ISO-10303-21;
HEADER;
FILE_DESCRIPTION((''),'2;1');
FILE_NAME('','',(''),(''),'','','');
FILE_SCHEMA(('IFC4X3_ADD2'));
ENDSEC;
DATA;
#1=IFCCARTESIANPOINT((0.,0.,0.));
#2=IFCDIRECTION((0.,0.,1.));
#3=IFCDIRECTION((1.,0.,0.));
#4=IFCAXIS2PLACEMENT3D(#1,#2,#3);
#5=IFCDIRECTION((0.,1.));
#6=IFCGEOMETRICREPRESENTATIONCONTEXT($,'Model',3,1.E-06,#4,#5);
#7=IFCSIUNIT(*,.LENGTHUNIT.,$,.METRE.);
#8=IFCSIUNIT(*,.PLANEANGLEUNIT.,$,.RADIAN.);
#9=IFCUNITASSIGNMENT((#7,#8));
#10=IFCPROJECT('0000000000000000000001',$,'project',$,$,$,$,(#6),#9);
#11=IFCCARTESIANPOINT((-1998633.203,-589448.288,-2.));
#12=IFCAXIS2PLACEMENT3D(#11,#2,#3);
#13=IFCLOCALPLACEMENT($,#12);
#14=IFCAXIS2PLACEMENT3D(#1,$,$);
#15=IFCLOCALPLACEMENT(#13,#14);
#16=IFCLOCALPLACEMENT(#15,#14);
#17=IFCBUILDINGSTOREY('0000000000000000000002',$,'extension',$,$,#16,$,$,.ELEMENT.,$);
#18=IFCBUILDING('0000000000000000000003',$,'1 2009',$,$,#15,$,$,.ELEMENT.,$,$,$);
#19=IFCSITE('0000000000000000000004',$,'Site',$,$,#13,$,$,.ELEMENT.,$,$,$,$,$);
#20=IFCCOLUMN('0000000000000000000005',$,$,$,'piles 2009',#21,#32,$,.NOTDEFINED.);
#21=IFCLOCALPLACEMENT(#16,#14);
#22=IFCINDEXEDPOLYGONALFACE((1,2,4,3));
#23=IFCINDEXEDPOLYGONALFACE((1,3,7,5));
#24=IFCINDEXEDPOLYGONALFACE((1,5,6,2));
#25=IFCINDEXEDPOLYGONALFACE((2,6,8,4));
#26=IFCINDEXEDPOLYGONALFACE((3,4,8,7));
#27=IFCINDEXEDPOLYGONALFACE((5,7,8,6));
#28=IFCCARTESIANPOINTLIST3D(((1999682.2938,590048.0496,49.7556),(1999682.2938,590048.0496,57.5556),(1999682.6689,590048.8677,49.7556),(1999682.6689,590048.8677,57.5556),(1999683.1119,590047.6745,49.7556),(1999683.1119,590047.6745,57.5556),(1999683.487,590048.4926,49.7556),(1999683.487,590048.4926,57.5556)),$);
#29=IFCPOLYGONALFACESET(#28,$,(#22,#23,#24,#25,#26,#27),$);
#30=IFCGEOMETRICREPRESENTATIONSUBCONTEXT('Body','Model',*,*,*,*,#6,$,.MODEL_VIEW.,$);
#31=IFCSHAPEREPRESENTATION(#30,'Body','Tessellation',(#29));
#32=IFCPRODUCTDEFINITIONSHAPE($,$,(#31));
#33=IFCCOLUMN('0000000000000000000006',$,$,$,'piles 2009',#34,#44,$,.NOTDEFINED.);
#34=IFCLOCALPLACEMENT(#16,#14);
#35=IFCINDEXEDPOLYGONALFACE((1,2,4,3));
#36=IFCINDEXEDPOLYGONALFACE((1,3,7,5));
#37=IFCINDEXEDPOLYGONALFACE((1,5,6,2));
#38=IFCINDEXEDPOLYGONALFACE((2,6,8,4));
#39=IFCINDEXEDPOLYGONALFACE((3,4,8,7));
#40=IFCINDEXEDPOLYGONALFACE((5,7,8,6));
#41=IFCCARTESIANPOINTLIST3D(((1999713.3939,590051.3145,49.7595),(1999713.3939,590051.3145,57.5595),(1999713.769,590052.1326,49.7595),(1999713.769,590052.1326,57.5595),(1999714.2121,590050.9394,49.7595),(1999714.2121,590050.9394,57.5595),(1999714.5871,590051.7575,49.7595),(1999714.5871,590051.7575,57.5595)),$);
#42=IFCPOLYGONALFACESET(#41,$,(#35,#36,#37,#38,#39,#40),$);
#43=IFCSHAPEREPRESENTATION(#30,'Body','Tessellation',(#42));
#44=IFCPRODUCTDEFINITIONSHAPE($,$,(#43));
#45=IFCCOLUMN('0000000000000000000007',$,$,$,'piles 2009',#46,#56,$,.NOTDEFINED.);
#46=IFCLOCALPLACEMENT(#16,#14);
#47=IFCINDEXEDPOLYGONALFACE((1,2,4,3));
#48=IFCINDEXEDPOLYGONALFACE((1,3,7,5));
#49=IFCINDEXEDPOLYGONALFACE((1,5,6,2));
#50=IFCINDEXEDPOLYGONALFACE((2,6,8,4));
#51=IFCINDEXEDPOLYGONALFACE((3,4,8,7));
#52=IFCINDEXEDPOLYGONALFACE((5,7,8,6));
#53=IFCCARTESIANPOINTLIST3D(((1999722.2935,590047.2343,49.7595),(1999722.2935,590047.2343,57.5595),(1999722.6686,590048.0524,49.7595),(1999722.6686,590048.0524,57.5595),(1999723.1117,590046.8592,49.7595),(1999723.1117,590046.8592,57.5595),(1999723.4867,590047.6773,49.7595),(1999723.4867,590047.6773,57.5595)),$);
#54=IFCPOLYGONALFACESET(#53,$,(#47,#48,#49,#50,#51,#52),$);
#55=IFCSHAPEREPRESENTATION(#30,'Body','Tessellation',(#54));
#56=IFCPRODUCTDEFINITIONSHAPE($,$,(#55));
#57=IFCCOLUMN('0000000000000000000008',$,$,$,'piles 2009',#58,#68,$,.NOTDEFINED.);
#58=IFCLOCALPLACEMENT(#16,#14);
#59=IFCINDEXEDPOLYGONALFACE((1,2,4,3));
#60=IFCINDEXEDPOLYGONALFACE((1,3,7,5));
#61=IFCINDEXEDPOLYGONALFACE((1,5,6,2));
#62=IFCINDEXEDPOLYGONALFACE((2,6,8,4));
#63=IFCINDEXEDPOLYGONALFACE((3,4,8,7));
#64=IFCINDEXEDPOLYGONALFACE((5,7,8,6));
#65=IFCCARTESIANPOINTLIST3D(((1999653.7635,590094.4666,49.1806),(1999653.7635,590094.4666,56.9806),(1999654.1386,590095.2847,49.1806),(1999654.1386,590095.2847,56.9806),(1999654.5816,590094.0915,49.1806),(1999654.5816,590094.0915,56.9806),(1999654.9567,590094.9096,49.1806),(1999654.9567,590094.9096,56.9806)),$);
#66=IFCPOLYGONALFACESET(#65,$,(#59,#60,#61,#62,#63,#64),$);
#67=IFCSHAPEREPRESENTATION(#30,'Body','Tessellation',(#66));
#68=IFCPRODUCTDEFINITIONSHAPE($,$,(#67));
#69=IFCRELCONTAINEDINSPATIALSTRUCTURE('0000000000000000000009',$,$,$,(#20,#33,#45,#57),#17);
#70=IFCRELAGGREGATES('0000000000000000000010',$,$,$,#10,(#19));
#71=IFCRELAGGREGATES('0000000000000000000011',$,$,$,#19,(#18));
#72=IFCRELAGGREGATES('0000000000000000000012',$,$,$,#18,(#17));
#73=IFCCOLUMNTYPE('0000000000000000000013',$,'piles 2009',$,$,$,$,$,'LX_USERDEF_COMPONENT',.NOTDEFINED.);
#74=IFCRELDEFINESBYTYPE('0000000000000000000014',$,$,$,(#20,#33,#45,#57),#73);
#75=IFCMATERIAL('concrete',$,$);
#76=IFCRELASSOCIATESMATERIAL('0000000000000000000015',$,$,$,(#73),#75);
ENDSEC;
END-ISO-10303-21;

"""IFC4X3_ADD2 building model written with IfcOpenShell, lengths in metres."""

from ifc_helpers import new_model, si_unit, direction, frame, frame_2d, origin, origin_with_axes, place, context, subcontext, project, spatial, rectangle, extrude, material, type_object, element, save


model = new_model("IFC4X3_ADD2")

# Units and contexts
model_context = context("Model", 3, precision=1e-06, world=origin_with_axes(), true_north=direction((0.0, 1.0)))
body_context = subcontext(model_context, "Body", "Model", "MODEL_VIEW")
ifc_project = project(units=[si_unit("LENGTHUNIT", "METRE"), si_unit("PLANEANGLEUNIT", "RADIAN")], contexts=[model_context])

# Site, building, storey
site_placement = place(None, frame((-1998633.203, -589448.288, -2.0), z_axis=(0.0, 0.0, 1.0), x_axis=(1.0, 0.0, 0.0)))
site = spatial("IfcSite", under=ifc_project, at=site_placement, Name="Site", CompositionType="ELEMENT")
building_placement = place(site_placement, origin())
building = spatial("IfcBuilding", under=site, at=building_placement, Name="1 2009", CompositionType="ELEMENT")
storey_placement = place(building_placement, origin())
storey = spatial("IfcBuildingStorey", under=building, at=storey_placement, Name="extension", CompositionType="ELEMENT")

# Columns
ifc_material = material(Name="concrete")
column_type = type_object("IfcColumnType", Name="piles 2009", ElementType="LX_USERDEF_COMPONENT", PredefinedType="NOTDEFINED", material=ifc_material)
for number, where, z_axis, x_axis in (
    (1, (1999683.1119, 590047.6745, 49.7556), (0.0, 0.0, 1.0), (0.416757, 0.909018, 0.0)),
    (2, (1999714.2121, 590050.9394, 49.7595), (0.0, 0.0, 1.0), (0.416757, 0.909018, 0.0)),
    (3, (1999723.1117, 590046.8592, 49.7595), (0.0, 0.0, 1.0), (0.416757, 0.909018, 0.0)),
    (4, (1999654.5816, 590094.0915, 49.1806), (0.0, 0.0, 1.0), (0.416757, 0.909018, 0.0)),
):
    element("IfcColumn", number, at=place(storey_placement, frame(where, z_axis=z_axis, x_axis=x_axis)), inside=storey, type_object=column_type, ObjectType="piles 2009", PredefinedType="NOTDEFINED", context=body_context, shape_type="SweptSolid", body=[
        extrude(rectangle(XDim=0.9, YDim=0.9, at=frame_2d((0.45, 0.45), x_axis=(1.0, 0.0))), origin_with_axes(), (0.0, 0.0, 1.0), 7.8),
    ])

save(model, "model.ifc")
